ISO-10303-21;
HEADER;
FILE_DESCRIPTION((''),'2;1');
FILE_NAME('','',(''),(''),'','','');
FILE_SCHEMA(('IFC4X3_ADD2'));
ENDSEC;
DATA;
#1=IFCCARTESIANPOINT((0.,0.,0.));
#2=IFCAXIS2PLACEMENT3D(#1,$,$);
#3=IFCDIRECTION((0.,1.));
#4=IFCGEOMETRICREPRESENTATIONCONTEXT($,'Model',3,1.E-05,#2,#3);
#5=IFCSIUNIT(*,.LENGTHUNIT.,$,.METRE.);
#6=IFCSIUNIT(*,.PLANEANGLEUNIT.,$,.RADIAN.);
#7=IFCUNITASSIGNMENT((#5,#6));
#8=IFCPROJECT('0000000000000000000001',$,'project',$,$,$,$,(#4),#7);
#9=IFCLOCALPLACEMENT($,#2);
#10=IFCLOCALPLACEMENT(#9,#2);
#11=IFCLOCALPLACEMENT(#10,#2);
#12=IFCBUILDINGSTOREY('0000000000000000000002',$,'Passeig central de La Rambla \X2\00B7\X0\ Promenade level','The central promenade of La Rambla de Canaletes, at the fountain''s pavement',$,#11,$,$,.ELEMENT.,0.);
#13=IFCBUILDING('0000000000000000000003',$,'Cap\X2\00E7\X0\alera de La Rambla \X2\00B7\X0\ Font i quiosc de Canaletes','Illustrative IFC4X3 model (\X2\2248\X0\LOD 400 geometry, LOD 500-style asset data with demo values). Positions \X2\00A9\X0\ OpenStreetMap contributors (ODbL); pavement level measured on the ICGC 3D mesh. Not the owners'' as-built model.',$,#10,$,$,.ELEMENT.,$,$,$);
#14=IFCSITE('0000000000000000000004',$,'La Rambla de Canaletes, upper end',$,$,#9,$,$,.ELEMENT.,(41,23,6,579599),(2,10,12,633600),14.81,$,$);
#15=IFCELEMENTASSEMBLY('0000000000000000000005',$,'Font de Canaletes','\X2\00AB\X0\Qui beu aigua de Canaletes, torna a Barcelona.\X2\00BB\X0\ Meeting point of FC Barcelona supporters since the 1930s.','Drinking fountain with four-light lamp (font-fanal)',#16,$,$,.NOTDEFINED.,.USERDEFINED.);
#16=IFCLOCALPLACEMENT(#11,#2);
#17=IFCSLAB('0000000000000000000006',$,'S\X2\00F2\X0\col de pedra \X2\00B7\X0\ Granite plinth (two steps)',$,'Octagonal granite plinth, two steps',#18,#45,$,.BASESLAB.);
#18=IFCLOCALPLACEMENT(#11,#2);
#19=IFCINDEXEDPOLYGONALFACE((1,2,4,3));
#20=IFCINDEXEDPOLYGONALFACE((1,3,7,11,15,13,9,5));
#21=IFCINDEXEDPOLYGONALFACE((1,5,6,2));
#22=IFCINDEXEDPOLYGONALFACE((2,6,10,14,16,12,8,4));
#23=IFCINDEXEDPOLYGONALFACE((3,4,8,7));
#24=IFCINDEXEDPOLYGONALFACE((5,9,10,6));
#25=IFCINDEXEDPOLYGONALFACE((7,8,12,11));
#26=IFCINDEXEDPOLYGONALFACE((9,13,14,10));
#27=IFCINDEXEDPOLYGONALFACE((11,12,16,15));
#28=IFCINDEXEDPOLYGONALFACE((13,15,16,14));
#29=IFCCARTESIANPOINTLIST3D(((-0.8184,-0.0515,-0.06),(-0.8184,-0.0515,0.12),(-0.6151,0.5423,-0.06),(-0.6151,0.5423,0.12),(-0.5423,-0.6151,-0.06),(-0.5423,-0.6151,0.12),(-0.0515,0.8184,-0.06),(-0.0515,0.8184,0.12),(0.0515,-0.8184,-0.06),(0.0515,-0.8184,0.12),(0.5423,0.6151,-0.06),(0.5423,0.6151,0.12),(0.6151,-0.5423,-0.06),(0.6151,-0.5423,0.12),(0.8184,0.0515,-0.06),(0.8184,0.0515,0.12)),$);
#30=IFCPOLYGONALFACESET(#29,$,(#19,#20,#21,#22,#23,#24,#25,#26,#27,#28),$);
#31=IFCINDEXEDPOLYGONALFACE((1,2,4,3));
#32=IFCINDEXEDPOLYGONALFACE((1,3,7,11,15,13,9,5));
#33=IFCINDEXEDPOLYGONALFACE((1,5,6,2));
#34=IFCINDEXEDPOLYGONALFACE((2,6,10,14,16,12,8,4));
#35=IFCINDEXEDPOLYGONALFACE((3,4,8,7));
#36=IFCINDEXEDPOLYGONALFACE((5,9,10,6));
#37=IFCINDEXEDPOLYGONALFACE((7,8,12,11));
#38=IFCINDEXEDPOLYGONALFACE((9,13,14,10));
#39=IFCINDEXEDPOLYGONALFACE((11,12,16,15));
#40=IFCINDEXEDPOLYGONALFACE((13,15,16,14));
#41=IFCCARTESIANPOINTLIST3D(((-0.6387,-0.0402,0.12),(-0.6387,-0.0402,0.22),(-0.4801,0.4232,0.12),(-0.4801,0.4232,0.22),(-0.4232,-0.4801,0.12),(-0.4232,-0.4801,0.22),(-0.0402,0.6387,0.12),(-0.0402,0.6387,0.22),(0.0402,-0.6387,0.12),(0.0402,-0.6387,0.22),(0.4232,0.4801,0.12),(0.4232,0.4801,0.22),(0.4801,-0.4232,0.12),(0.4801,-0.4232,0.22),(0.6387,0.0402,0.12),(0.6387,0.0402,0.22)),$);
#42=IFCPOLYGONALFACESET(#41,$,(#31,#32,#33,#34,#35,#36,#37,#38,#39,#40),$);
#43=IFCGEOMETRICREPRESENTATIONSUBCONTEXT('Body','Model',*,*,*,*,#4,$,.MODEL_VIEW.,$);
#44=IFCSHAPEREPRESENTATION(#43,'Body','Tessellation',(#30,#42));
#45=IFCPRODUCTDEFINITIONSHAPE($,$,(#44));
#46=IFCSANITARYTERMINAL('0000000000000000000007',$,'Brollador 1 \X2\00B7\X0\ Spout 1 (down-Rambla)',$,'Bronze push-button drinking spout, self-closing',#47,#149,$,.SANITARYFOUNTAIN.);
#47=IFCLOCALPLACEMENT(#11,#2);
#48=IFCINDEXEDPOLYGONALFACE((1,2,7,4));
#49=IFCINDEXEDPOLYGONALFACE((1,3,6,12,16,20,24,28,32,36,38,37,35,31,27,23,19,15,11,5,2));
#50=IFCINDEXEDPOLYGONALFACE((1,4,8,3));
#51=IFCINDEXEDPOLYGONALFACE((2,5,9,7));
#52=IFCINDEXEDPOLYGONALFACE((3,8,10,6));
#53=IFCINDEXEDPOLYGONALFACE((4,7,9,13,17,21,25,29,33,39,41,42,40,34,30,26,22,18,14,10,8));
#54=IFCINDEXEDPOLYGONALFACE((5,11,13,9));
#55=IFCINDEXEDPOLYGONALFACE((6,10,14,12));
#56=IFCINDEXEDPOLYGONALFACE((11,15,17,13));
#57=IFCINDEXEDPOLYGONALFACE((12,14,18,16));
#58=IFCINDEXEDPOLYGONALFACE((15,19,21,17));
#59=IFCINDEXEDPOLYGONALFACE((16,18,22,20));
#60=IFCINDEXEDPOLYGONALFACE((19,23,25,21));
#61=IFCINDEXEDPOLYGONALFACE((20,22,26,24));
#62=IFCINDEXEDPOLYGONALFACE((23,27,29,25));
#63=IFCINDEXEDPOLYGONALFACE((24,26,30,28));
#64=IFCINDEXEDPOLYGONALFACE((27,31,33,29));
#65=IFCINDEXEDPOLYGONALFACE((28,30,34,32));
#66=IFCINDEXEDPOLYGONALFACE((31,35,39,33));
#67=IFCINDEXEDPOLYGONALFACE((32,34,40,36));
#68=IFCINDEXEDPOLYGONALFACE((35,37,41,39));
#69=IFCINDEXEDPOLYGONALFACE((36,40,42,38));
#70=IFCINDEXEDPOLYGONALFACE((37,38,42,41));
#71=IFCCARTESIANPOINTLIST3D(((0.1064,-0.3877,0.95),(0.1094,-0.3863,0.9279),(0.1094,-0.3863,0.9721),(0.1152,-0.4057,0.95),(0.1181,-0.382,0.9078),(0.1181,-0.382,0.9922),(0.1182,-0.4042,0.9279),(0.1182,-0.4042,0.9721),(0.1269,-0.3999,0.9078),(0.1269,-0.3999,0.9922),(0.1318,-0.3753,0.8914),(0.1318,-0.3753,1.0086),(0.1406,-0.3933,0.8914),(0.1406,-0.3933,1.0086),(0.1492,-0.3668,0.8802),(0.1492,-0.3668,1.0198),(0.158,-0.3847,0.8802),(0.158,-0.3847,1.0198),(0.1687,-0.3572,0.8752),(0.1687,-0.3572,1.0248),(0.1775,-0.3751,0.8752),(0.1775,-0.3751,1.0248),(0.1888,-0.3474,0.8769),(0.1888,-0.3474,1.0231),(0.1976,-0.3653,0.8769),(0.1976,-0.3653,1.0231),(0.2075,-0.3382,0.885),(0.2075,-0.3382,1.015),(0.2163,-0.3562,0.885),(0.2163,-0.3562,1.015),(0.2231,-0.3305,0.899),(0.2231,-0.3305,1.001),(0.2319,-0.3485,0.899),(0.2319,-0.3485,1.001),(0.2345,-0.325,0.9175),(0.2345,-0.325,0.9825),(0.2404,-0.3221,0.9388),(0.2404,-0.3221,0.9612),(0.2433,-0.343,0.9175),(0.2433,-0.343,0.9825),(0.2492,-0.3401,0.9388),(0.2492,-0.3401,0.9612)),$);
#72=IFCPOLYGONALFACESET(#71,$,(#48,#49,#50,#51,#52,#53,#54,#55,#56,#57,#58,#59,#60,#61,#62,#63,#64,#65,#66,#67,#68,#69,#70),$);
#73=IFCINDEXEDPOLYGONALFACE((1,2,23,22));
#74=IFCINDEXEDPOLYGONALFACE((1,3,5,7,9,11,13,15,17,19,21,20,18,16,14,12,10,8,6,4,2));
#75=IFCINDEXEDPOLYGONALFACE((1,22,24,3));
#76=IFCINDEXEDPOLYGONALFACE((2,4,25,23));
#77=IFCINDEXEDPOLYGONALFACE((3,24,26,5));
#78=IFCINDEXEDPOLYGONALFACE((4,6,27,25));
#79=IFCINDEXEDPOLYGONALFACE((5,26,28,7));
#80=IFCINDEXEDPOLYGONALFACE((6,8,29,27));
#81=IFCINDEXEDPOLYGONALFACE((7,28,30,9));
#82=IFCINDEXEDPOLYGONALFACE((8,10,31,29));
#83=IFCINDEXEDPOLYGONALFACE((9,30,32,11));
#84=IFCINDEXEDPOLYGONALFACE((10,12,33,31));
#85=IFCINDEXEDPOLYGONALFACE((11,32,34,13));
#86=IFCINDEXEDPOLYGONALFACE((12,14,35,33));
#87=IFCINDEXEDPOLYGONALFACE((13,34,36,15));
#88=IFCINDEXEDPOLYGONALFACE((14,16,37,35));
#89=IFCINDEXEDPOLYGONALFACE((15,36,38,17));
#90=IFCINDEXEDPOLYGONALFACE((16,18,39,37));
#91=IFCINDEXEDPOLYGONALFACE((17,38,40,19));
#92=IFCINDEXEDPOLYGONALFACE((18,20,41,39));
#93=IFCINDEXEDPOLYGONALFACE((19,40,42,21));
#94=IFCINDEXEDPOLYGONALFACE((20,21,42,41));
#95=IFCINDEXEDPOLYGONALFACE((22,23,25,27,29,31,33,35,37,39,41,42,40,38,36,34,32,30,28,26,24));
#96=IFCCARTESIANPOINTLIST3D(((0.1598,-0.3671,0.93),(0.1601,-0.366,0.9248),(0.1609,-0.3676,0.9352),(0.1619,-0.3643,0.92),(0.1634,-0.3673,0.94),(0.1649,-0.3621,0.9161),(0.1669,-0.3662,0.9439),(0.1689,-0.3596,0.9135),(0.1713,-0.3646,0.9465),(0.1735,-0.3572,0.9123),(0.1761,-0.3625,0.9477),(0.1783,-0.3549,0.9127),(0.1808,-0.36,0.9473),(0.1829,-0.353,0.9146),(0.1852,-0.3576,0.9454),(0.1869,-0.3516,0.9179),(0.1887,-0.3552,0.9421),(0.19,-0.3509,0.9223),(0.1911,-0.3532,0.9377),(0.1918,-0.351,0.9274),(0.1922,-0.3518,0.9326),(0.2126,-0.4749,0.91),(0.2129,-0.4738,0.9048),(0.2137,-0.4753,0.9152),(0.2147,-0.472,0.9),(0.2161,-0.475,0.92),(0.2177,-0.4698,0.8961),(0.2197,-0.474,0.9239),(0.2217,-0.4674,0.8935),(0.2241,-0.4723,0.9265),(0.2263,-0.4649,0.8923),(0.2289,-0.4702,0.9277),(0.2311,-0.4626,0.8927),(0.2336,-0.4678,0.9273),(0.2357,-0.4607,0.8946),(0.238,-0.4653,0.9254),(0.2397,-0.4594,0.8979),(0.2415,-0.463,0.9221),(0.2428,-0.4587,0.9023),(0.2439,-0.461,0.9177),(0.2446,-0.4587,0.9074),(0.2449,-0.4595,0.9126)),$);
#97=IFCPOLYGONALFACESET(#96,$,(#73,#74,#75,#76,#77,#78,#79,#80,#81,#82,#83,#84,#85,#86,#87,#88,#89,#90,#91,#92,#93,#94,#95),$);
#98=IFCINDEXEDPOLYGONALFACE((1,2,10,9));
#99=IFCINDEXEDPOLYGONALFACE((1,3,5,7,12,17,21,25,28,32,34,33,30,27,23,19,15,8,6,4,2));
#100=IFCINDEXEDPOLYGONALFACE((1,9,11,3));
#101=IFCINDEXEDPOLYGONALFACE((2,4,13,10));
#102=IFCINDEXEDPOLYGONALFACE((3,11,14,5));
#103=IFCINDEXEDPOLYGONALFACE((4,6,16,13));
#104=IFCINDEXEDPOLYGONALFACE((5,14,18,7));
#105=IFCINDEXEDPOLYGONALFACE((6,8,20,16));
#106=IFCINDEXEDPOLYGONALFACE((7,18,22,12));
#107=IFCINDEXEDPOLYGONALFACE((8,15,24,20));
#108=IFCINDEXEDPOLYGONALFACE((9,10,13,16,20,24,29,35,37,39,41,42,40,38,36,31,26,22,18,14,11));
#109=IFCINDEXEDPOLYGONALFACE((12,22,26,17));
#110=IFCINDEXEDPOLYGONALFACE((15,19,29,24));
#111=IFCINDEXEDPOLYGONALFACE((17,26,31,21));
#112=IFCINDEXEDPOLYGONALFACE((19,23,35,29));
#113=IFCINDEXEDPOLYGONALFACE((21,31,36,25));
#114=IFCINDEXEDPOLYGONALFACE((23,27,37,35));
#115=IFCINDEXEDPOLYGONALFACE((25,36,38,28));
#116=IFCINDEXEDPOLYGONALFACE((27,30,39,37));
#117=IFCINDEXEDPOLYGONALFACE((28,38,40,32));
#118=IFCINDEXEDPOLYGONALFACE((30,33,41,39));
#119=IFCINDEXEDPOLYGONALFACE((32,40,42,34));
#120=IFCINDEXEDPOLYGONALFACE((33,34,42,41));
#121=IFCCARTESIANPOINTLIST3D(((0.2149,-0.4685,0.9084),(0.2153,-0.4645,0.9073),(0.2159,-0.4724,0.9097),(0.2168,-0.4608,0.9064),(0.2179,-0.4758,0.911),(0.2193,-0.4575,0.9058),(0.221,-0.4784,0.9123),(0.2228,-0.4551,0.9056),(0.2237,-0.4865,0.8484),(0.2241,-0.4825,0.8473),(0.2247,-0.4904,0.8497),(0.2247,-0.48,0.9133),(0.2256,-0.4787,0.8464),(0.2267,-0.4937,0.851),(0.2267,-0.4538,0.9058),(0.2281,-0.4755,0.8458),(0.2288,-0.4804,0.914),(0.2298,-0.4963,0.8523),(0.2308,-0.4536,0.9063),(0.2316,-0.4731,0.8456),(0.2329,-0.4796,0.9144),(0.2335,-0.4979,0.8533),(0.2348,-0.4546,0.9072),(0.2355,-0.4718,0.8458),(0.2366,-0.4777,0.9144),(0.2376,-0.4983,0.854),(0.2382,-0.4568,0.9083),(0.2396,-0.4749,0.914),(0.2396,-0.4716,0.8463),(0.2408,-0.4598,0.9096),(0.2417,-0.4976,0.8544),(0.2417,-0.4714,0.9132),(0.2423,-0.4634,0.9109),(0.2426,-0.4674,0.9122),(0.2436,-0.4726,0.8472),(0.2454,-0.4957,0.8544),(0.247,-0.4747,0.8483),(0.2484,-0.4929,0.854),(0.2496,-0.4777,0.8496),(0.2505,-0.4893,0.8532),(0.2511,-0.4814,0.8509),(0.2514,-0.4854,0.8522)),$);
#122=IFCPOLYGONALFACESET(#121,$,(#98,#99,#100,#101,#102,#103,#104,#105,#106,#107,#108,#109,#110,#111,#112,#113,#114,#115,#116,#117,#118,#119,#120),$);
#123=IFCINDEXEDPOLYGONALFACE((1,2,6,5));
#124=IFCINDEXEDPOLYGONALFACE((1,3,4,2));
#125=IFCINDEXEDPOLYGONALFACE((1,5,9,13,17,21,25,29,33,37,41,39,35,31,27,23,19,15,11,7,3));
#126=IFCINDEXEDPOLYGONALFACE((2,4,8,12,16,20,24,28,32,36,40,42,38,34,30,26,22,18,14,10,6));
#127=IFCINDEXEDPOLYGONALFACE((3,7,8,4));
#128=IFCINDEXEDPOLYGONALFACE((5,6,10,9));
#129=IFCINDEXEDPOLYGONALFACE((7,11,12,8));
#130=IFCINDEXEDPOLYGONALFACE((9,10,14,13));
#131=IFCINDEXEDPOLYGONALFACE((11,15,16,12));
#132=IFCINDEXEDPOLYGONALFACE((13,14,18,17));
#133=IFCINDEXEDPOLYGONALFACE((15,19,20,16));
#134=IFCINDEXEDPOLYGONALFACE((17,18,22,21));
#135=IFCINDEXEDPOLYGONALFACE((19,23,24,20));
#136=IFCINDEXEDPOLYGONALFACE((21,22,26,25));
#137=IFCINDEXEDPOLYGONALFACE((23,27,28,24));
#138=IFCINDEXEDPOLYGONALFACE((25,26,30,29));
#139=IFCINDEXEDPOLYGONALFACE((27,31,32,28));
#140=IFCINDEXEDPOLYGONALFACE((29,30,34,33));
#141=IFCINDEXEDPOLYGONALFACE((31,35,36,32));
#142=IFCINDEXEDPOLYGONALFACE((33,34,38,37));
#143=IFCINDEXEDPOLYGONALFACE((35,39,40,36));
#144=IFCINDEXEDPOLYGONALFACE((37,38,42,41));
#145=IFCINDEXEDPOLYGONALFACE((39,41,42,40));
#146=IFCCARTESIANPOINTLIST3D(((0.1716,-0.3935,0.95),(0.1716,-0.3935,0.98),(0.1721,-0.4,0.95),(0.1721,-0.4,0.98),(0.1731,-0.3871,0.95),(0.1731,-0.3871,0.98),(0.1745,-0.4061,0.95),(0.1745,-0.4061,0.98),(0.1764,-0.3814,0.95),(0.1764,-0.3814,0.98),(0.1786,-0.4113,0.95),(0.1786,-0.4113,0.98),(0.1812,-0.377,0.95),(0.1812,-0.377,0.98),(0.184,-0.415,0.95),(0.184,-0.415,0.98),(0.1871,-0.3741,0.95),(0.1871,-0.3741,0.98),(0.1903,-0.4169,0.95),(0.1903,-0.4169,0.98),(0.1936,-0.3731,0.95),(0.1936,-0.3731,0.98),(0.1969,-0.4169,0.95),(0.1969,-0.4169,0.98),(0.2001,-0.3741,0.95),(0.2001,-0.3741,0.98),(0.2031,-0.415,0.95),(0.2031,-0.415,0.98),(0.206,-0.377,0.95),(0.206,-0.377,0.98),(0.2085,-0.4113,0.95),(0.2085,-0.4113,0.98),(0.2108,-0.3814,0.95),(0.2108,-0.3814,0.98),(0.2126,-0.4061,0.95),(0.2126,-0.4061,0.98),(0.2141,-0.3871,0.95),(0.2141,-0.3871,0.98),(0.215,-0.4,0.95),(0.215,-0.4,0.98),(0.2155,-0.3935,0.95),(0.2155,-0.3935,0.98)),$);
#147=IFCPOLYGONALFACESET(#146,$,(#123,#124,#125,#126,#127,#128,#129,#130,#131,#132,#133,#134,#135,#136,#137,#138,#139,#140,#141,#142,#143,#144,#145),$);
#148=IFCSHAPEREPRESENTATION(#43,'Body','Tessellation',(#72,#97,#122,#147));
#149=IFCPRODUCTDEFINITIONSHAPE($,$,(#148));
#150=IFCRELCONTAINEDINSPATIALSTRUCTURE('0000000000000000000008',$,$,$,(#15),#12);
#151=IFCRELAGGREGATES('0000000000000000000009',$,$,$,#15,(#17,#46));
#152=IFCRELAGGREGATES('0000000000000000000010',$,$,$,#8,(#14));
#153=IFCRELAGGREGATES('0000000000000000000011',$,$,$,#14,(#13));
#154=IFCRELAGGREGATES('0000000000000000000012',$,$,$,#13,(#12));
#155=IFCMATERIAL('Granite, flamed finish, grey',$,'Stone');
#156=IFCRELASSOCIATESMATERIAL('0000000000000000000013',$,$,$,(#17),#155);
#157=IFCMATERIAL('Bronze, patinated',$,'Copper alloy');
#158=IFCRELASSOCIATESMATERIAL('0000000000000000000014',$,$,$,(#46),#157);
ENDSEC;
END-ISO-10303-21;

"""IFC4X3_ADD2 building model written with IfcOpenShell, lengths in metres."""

from ifc_helpers import new_model, si_unit, direction, frame, origin, origin_2d_with_axis, place, context, subcontext, project, spatial, polyline, circle, outline, extrude, material, element, aggregate, save


model = new_model("IFC4X3_ADD2")

# Units and contexts
model_context = context("Model", 3, precision=1e-05, world=origin(), true_north=direction((0.0, 1.0)))
body_context = subcontext(model_context, "Body", "Model", "MODEL_VIEW")
ifc_project = project(units=[si_unit("LENGTHUNIT", "METRE"), si_unit("PLANEANGLEUNIT", "RADIAN")], contexts=[model_context])

# Site, building, storey
site_placement = place(None, origin())
site = spatial("IfcSite", under=ifc_project, at=site_placement, Name="La Rambla de Canaletes, upper end", CompositionType="ELEMENT", RefLatitude=(41, 23, 6, 579599), RefLongitude=(2, 10, 12, 633600), RefElevation=14.81)
building_placement = place(site_placement, origin())
building = spatial("IfcBuilding", under=site, at=building_placement, Name="Capçalera de La Rambla · Font i quiosc de Canaletes", Description="Illustrative IFC4X3 model (≈LOD 400 geometry, LOD 500-style asset data with demo values). Positions © OpenStreetMap contributors (ODbL); pavement level measured on the ICGC 3D mesh. Not the owners' as-built model.", CompositionType="ELEMENT")
storey_placement = place(building_placement, origin())
storey = spatial("IfcBuildingStorey", under=building, at=storey_placement, Name="Passeig central de La Rambla · Promenade level", Description="The central promenade of La Rambla de Canaletes, at the fountain's pavement", CompositionType="ELEMENT", Elevation=0.0)

# Element assembly, slab, sanitary terminal
assembly_1_placement = place(building_placement, origin())
assembly_1 = element("IfcElementAssembly", 1, at=assembly_1_placement, inside=storey, Name="Font de Canaletes", Description="«Qui beu aigua de Canaletes, torna a Barcelona.» Meeting point of FC Barcelona supporters since the 1930s.", ObjectType="Drinking fountain with four-light lamp (font-fanal)", AssemblyPlace="NOTDEFINED", PredefinedType="USERDEFINED")
ifc_material_1 = material(Name="Granite, flamed finish, grey", Category="Stone")
slab_placement = place(building_placement, origin())
slab = element("IfcSlab", 2, at=slab_placement, material=ifc_material_1, Name="Sòcol de pedra · Granite plinth (two steps)", ObjectType="Octagonal granite plinth, two steps", PredefinedType="BASESLAB", context=body_context, shape_type="SweptSolid", body=[
    extrude(outline(polyline([(0.6151, -0.5423), (0.8184, 0.0515), (0.5423, 0.6151), (-0.0515, 0.8184), (-0.6151, 0.5423), (-0.8184, -0.0515), (-0.5423, -0.6151), (0.0515, -0.8184), (0.6151, -0.5423)])), frame((0.0, 0.0, -0.06)), (0.0, 0.0, 1.0), 0.18),
    extrude(outline(polyline([(0.4801, -0.4232), (0.6387, 0.0402), (0.4232, 0.4801), (-0.0402, 0.6387), (-0.4801, 0.4232), (-0.6387, -0.0402), (-0.4232, -0.4801), (0.0402, -0.6387), (0.4801, -0.4232)])), frame((0.0, 0.0, 0.12)), (0.0, 0.0, 1.0), 0.1),
])
ifc_material_2 = material(Name="Bronze, patinated", Category="Copper alloy")
sanitary_terminal_1_placement = place(building_placement, origin())
sanitary_terminal_1 = element("IfcSanitaryTerminal", 3, at=sanitary_terminal_1_placement, material=ifc_material_2, Name="Brollador 1 · Spout 1 (down-Rambla)", ObjectType="Bronze push-button drinking spout, self-closing", PredefinedType="SANITARYFOUNTAIN", context=body_context, shape_type="SweptSolid", body=[
    extrude(circle(Radius=0.075, at=origin_2d_with_axis()), frame((0.1738, -0.3547, 0.95), z_axis=(0.439939, -0.898028, 0.0), x_axis=(-0.898028, -0.439939, 0.0)), (0.0, 0.0, 1.0), 0.02),
    extrude(circle(Radius=0.018, at=origin_2d_with_axis()), frame((0.176, -0.3592, 0.93), z_axis=(0.433953, -0.885809, -0.164399), x_axis=(-0.898028, -0.439939, 0.0)), (0.0, 0.0, 1.0), 0.1217),
    extrude(circle(Radius=0.014, at=origin_2d_with_axis()), frame((0.2288, -0.467, 0.91), z_axis=(0.139121, -0.283981, -0.948683), x_axis=(0.0, -0.957999, 0.28677)), (0.0, 0.0, 1.0), 0.0632),
    extrude(circle(Radius=0.022, at=origin_2d_with_axis()), frame((0.1936, -0.3951, 0.95), z_axis=(0.0, 0.0, 1.0), x_axis=(0.0, 1.0, 0.0)), (0.0, 0.0, 1.0), 0.03),
])
aggregate(assembly_1, [slab, sanitary_terminal_1])

save(model, "model.ifc")
